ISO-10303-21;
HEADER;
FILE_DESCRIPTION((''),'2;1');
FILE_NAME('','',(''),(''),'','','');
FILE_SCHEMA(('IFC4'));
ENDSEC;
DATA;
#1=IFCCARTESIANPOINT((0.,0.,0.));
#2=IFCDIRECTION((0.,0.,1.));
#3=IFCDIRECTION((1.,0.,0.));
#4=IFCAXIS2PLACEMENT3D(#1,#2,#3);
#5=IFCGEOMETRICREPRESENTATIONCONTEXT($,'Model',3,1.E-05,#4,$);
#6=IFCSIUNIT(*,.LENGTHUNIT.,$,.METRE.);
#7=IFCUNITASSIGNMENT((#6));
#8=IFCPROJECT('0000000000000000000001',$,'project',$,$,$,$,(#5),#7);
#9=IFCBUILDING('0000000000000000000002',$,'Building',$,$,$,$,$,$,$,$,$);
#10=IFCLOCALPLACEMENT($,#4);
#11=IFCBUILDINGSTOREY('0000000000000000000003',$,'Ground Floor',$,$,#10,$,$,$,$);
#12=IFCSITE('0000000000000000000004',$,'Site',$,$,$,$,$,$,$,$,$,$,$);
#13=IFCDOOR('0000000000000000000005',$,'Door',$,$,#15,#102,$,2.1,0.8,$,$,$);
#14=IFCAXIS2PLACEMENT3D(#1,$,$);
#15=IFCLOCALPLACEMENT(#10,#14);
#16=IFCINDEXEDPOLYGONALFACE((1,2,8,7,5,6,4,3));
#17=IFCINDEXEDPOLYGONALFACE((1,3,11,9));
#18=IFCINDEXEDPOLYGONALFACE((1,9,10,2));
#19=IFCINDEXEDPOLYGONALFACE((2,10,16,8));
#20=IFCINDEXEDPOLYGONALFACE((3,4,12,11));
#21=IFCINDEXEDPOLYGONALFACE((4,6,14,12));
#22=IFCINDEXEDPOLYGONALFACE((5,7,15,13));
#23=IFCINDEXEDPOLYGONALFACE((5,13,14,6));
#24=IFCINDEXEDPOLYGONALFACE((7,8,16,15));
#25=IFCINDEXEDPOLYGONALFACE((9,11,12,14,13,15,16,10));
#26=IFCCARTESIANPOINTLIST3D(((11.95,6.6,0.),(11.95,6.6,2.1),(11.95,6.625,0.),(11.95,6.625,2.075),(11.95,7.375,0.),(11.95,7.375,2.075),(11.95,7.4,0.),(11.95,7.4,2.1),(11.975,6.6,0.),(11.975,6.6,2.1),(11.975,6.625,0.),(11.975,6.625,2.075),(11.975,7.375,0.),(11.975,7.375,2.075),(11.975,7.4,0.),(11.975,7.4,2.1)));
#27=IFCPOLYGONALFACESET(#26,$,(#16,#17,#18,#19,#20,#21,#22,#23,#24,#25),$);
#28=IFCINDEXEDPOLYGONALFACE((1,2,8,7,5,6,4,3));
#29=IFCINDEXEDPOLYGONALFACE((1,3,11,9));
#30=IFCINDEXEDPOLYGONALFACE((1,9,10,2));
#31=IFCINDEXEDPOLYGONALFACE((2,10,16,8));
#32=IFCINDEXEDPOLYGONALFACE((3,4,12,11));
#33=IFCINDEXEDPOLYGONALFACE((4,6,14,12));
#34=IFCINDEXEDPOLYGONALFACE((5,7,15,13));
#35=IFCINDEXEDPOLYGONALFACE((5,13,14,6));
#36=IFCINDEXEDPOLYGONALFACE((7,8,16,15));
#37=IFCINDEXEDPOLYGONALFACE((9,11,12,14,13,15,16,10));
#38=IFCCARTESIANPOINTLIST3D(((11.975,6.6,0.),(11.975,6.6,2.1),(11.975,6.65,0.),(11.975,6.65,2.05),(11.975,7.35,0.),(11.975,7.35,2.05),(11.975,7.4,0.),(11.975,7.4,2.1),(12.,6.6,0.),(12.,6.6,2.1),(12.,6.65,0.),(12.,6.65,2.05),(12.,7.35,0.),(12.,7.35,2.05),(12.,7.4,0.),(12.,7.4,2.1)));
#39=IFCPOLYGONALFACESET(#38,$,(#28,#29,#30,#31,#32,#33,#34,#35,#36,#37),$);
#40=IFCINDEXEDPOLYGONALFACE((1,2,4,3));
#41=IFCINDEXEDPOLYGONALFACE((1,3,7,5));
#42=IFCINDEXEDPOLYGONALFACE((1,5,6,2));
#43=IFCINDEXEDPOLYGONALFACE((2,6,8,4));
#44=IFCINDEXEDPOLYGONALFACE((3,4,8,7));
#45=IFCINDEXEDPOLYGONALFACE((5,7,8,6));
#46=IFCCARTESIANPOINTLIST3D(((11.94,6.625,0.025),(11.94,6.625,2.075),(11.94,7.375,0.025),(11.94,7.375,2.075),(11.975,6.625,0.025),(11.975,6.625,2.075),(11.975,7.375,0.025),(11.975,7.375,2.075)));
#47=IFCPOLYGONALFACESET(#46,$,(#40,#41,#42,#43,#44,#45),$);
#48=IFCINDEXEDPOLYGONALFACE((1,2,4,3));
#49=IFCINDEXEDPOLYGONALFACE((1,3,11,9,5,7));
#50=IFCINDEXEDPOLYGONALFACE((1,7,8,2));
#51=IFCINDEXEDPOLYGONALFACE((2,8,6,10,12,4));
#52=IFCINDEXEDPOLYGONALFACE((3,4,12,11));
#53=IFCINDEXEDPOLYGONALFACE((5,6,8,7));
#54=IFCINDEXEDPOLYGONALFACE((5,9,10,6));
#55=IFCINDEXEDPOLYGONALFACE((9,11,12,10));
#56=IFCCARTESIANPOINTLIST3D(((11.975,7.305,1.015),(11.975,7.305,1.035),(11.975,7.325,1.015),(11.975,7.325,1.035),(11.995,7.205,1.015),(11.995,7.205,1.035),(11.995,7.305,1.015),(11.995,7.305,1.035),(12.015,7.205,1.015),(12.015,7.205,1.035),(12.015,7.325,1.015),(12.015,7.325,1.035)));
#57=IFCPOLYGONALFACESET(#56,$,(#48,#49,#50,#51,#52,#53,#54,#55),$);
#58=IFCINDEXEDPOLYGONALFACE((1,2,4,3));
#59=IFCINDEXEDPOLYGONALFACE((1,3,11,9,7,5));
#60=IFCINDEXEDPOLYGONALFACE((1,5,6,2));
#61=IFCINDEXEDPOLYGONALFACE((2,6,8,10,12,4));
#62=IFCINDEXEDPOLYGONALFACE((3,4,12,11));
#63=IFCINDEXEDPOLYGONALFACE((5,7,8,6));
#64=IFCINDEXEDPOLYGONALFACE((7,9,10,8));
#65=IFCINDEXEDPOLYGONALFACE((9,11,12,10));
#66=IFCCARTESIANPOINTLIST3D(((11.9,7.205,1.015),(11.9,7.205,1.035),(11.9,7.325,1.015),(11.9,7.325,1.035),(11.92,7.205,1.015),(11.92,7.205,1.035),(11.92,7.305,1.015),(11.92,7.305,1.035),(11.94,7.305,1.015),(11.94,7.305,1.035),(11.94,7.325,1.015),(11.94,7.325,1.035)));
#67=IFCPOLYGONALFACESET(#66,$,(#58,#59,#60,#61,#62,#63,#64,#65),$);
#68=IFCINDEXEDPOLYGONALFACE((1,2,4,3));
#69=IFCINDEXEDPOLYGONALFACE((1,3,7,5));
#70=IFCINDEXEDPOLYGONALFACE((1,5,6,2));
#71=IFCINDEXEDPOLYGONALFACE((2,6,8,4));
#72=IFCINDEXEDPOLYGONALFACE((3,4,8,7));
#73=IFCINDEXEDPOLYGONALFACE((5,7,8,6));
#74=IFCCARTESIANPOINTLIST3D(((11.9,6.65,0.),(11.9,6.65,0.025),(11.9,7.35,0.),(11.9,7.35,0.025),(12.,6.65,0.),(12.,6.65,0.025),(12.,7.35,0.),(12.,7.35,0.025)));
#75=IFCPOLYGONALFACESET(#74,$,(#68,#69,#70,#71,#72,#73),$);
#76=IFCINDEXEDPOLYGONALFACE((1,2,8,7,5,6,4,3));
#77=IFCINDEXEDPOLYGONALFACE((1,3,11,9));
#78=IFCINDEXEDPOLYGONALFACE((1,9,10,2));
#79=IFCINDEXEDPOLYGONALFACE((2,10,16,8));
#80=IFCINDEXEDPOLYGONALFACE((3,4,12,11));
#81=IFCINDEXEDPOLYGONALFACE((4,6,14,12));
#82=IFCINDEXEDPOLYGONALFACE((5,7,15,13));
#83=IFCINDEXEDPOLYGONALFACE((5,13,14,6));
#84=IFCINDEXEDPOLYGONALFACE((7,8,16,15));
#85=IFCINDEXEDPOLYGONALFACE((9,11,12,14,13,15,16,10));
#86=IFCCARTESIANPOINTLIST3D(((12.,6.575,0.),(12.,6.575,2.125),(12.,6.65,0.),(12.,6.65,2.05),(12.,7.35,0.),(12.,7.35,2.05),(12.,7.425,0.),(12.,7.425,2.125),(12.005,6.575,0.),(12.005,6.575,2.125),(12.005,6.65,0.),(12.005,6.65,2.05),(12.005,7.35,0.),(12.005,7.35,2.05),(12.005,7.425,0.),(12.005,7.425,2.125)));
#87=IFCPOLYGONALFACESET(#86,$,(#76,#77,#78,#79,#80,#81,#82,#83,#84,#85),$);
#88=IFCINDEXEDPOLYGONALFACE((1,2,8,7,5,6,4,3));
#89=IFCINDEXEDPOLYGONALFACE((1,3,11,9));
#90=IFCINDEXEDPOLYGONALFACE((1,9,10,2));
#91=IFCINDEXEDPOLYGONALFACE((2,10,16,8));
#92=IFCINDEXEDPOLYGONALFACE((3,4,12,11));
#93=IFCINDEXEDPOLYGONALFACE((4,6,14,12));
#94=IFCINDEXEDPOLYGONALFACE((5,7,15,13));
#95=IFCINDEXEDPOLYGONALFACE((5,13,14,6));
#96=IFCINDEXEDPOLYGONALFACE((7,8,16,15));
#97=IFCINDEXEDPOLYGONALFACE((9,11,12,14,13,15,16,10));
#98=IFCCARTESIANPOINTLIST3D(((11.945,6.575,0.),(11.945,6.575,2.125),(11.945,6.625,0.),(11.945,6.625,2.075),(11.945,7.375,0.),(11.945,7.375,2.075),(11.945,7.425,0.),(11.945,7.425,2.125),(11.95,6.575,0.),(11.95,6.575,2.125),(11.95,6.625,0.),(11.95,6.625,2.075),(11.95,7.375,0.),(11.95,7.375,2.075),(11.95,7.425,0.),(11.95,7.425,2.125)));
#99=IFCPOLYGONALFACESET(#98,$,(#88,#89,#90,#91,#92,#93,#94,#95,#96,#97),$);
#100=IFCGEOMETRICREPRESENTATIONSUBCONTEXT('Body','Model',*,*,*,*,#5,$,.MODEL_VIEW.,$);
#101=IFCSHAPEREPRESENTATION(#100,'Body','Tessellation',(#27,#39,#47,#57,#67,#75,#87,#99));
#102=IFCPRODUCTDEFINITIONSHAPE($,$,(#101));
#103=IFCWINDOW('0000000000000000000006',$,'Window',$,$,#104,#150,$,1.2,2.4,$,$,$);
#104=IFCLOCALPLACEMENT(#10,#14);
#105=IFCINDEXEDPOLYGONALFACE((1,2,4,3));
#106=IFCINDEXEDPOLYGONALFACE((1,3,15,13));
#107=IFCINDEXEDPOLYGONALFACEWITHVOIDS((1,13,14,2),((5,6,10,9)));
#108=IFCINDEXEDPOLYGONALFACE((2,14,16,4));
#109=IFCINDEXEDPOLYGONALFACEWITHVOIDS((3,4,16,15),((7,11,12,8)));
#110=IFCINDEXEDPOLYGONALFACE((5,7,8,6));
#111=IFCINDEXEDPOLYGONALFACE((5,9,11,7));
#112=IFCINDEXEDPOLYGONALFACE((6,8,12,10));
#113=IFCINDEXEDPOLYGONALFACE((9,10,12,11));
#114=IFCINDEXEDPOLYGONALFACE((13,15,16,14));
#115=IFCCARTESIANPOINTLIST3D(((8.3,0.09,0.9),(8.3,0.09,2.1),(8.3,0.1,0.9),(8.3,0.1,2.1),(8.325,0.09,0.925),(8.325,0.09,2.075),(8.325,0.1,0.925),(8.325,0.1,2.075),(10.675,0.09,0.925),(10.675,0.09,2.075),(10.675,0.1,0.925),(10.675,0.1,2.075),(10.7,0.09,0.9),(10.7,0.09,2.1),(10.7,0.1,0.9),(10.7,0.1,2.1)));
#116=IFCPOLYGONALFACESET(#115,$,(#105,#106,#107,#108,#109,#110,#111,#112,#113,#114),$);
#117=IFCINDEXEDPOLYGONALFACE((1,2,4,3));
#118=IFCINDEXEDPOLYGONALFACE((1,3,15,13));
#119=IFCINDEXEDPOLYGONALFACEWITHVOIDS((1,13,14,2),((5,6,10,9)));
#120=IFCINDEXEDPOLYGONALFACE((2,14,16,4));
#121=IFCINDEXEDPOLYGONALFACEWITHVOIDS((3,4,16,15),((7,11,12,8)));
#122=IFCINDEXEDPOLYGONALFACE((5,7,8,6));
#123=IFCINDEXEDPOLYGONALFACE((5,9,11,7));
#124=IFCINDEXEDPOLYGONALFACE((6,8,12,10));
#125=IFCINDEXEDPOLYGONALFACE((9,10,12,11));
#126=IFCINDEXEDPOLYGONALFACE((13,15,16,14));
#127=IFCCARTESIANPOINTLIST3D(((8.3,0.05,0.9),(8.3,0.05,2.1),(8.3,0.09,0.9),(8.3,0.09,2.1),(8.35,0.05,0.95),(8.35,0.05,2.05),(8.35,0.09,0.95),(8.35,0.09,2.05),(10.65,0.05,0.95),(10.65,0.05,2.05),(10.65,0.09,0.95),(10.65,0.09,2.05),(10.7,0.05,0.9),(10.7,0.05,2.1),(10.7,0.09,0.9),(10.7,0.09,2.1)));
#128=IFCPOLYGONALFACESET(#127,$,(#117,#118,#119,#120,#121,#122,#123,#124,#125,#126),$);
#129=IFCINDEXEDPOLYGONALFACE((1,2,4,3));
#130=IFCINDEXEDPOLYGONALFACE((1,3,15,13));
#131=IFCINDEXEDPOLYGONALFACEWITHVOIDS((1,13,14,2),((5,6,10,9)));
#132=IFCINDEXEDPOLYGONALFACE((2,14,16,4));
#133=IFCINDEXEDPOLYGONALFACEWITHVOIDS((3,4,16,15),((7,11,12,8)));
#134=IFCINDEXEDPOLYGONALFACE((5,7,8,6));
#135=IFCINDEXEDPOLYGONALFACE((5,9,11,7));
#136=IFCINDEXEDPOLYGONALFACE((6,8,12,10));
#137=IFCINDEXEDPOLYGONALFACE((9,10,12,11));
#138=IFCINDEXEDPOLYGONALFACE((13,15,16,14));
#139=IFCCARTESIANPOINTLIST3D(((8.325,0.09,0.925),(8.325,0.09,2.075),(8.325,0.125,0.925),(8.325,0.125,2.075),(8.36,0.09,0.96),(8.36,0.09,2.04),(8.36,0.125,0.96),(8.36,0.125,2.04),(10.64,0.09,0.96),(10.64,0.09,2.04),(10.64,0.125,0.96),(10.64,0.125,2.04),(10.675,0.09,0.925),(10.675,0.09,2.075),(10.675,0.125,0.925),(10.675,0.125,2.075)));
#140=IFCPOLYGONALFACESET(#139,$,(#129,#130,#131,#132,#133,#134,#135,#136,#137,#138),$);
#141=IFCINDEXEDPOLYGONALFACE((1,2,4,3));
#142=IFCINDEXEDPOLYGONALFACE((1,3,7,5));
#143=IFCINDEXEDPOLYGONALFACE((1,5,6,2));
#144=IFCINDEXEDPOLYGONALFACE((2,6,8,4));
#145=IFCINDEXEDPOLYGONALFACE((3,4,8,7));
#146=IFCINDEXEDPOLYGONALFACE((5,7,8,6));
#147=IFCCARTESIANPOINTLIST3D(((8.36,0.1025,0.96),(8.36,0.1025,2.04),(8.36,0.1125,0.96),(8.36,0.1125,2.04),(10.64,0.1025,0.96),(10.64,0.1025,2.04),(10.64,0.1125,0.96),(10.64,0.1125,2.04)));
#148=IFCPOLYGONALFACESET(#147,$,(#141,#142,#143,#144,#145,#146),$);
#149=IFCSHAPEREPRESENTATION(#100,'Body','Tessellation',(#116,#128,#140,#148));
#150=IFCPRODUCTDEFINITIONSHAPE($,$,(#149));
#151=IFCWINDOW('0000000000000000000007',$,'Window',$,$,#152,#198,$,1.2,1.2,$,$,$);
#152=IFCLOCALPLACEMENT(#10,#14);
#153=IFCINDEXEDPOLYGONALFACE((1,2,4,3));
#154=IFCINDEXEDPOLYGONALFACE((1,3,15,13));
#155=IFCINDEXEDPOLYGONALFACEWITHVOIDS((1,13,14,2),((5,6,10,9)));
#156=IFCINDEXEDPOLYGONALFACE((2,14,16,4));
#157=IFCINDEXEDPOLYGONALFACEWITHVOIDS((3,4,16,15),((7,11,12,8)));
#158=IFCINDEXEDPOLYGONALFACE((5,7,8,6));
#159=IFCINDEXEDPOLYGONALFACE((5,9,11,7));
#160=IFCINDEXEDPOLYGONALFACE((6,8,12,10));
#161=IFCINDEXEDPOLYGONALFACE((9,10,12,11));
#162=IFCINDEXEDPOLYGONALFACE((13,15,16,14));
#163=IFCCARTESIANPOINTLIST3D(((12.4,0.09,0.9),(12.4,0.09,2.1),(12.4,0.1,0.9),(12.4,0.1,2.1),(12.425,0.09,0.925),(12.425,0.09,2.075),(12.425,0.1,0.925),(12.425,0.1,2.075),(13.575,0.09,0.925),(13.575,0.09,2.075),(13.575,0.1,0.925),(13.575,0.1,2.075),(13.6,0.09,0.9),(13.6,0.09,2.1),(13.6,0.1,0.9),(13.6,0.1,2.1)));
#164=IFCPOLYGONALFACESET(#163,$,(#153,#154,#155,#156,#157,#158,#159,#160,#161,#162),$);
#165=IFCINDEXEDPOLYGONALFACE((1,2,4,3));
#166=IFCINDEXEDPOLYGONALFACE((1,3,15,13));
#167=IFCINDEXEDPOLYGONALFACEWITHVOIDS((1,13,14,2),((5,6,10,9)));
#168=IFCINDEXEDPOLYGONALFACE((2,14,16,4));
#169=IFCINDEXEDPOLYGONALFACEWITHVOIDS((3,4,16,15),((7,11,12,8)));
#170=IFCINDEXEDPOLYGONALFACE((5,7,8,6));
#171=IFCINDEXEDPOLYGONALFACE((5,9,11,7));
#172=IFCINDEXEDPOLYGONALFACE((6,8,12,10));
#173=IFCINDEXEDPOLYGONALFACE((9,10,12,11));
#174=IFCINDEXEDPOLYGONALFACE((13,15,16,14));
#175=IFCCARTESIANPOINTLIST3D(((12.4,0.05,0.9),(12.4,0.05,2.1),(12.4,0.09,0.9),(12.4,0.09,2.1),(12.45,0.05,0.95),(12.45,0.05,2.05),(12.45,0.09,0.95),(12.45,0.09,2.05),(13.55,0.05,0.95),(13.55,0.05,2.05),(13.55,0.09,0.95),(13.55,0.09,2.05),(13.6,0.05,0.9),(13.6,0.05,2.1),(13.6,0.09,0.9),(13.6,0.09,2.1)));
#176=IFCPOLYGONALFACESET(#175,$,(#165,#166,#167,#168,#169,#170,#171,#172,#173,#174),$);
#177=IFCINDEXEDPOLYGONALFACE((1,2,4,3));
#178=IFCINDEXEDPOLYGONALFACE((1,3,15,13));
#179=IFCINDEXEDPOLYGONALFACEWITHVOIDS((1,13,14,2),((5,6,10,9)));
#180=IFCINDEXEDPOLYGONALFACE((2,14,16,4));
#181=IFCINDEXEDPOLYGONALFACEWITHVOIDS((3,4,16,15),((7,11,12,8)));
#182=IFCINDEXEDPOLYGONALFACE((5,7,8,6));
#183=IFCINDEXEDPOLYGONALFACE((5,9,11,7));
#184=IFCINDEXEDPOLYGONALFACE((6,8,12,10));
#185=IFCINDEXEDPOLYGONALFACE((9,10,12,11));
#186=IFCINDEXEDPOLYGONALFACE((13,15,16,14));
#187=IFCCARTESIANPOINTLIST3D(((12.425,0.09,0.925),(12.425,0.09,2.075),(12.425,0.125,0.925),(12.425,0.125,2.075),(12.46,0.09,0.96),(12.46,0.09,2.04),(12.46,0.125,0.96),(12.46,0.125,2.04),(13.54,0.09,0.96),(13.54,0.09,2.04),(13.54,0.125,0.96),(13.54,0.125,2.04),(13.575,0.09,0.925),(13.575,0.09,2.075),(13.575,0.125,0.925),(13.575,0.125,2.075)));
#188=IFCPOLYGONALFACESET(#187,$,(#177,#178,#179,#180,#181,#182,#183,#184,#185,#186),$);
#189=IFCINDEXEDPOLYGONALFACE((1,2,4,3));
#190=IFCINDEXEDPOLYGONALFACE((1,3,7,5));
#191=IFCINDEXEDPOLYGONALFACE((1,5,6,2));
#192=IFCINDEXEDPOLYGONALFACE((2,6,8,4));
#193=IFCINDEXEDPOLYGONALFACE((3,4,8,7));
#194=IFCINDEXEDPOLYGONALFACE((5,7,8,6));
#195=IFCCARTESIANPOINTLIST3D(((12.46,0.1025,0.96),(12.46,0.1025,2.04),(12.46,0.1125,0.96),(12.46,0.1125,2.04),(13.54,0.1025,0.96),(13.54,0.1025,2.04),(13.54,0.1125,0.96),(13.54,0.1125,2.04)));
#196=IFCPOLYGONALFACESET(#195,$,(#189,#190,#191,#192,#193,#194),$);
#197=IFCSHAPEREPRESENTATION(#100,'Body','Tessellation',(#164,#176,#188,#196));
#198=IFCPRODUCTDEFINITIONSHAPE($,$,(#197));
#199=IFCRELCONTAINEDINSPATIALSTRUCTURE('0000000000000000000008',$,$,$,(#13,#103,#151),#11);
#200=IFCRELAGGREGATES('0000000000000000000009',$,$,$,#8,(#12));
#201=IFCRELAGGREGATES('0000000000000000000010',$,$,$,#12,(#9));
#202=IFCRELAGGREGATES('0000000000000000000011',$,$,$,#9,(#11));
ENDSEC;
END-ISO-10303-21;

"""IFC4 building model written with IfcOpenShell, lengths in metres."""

from ifc_helpers import new_model, si_unit, frame, origin_with_axes, place, context, subcontext, project, spatial, line, indexed_curve, outline, extrude, element, save


model = new_model("IFC4")

# Units and contexts
model_context = context("Model", 3, precision=1e-05, world=origin_with_axes())
body_context = subcontext(model_context, "Body", "Model", "MODEL_VIEW")
ifc_project = project(units=[si_unit("LENGTHUNIT", "METRE")], contexts=[model_context])

# Site, building, storey
site = spatial("IfcSite", under=ifc_project, Name="Site")
building = spatial("IfcBuilding", under=site, Name="Building")
storey_placement = place(None, origin_with_axes())
storey = spatial("IfcBuildingStorey", under=building, at=storey_placement, Name="Ground Floor")

# Door
door_1_placement = place(storey_placement, frame((12.0, 6.6, 0.0), z_axis=(0.0, 0.0, 1.0), x_axis=(0.0, 1.0, 0.0)))
element("IfcDoor", 1, at=door_1_placement, inside=storey, Name="Door", OverallHeight=2.1, OverallWidth=0.8, context=body_context, shape_type="SweptSolid", body=[
    extrude(outline(indexed_curve([(0.0, 0.0), (0.0, 2.1), (0.8, 2.1), (0.8, 0.0), (0.775, 0.0), (0.775, 2.075), (0.025, 2.075), (0.025, 0.0)], segments=[line(1, 2, 3, 4, 5, 6, 7, 8, 1)])), frame((0.0, 0.025, 0.0), z_axis=(0.0, -1.0, 0.0), x_axis=(1.0, 0.0, 0.0)), (0.0, 0.0, -1.0), 0.025),
    extrude(outline(indexed_curve([(0.0, 0.0), (0.0, 2.1), (0.8, 2.1), (0.8, 0.0), (0.75, 0.0), (0.75, 2.05), (0.05, 2.05), (0.05, 0.0)], segments=[line(1, 2, 3, 4, 5, 6, 7, 8, 1)])), frame((0.0, 0.0, 0.0), z_axis=(0.0, -1.0, 0.0), x_axis=(1.0, 0.0, 0.0)), (0.0, 0.0, -1.0), 0.025),
    extrude(outline(indexed_curve([(0.0, 0.0), (0.75, 0.0), (0.75, 0.035), (0.0, 0.035)], segments=[line(1, 2, 3, 4, 1)])), frame((0.025, 0.025, 0.025), z_axis=(0.0, 0.0, 1.0), x_axis=(1.0, 0.0, 0.0)), (0.0, 0.0, 1.0), 2.05),
    extrude(outline(indexed_curve([(0.0, 0.0), (0.0, -0.04), (-0.12, -0.04), (-0.12, -0.02), (-0.02, -0.02), (-0.02, 0.0)], segments=[line(1, 2, 3, 4, 5, 6, 1)])), frame((0.725, 0.025, 1.015), z_axis=(0.0, 0.0, 1.0), x_axis=(1.0, 0.0, 0.0)), (0.0, 0.0, 1.0), 0.02),
    extrude(outline(indexed_curve([(0.0, 0.0), (0.0, 0.04), (-0.12, 0.04), (-0.12, 0.02), (-0.02, 0.02), (-0.02, 0.0)], segments=[line(1, 2, 3, 4, 5, 6, 1)])), frame((0.725, 0.06, 1.015), z_axis=(0.0, 0.0, 1.0), x_axis=(1.0, 0.0, 0.0)), (0.0, 0.0, 1.0), 0.02),
    extrude(outline(indexed_curve([(0.0, 0.0), (0.7, 0.0), (0.7, 0.1), (0.0, 0.1)], segments=[line(1, 2, 3, 4, 1)])), frame((0.05, 0.0, 0.0), z_axis=(0.0, 0.0, 1.0), x_axis=(1.0, 0.0, 0.0)), (0.0, 0.0, 1.0), 0.025),
    extrude(outline(indexed_curve([(0.0, 0.0), (0.0, 2.125), (0.85, 2.125), (0.85, 0.0), (0.775, 0.0), (0.775, 2.05), (0.075, 2.05), (0.075, 0.0)], segments=[line(1, 2, 3, 4, 5, 6, 7, 8, 1)])), frame((-0.025, -0.005, 0.0), z_axis=(0.0, -1.0, 0.0), x_axis=(1.0, 0.0, 0.0)), (0.0, 0.0, -1.0), 0.005),
    extrude(outline(indexed_curve([(0.0, 0.0), (0.0, 2.125), (0.85, 2.125), (0.85, 0.0), (0.8, 0.0), (0.8, 2.075), (0.05, 2.075), (0.05, 0.0)], segments=[line(1, 2, 3, 4, 5, 6, 7, 8, 1)])), frame((-0.025, 0.05, 0.0), z_axis=(0.0, -1.0, 0.0), x_axis=(1.0, 0.0, 0.0)), (0.0, 0.0, -1.0), 0.005),
])

# Windows
window_1_placement = place(storey_placement, frame((8.3, 0.0, 0.9), z_axis=(0.0, 0.0, 1.0), x_axis=(1.0, 0.0, 0.0)))
element("IfcWindow", 2, at=window_1_placement, inside=storey, Name="Window", OverallHeight=1.2, OverallWidth=2.4, context=body_context, shape_type="SweptSolid", body=[
    extrude(outline(indexed_curve([(0.0, 0.0), (2.4, 0.0), (2.4, 1.2), (0.0, 1.2)], segments=[line(1, 2, 3, 4, 1)]), holes=[indexed_curve([(0.025, 0.025), (2.375, 0.025), (2.375, 1.175), (0.025, 1.175)], segments=[line(1, 2, 3, 4, 1)])]), frame((0.0, 0.09, 0.0), z_axis=(0.0, -1.0, 0.0), x_axis=(1.0, 0.0, 0.0)), (0.0, 0.0, -1.0), 0.01),
    extrude(outline(indexed_curve([(0.0, 0.0), (2.4, 0.0), (2.4, 1.2), (0.0, 1.2)], segments=[line(1, 2, 3, 4, 1)]), holes=[indexed_curve([(0.05, 0.05), (2.35, 0.05), (2.35, 1.15), (0.05, 1.15)], segments=[line(1, 2, 3, 4, 1)])]), frame((0.0, 0.05, 0.0), z_axis=(0.0, -1.0, 0.0), x_axis=(1.0, 0.0, 0.0)), (0.0, 0.0, -1.0), 0.04),
    extrude(outline(indexed_curve([(0.0, 0.0), (2.35, 0.0), (2.35, 1.15), (0.0, 1.15)], segments=[line(1, 2, 3, 4, 1)]), holes=[indexed_curve([(0.035, 0.035), (2.315, 0.035), (2.315, 1.115), (0.035, 1.115)], segments=[line(1, 2, 3, 4, 1)])]), frame((0.025, 0.09, 0.025), z_axis=(0.0, -1.0, 0.0), x_axis=(1.0, 0.0, 0.0)), (0.0, 0.0, -1.0), 0.035),
    extrude(outline(indexed_curve([(0.035, 0.035), (2.315, 0.035), (2.315, 1.115), (0.035, 1.115)], segments=[line(1, 2, 3, 4, 1)])), frame((0.025, 0.1025, 0.025), z_axis=(0.0, -1.0, 0.0), x_axis=(1.0, 0.0, 0.0)), (0.0, 0.0, -1.0), 0.01),
])
for number, where, z_axis, x_axis, name in (
    (3, (12.4, 0.0, 0.9), (0.0, 0.0, 1.0), (1.0, 0.0, 0.0), "Window"),
):
    element("IfcWindow", number, at=place(storey_placement, frame(where, z_axis=z_axis, x_axis=x_axis)), inside=storey, Name=name, OverallHeight=1.2, OverallWidth=1.2, context=body_context, shape_type="SweptSolid", body=[
        extrude(outline(indexed_curve([(0.0, 0.0), (1.2, 0.0), (1.2, 1.2), (0.0, 1.2)], segments=[line(1, 2, 3, 4, 1)]), holes=[indexed_curve([(0.025, 0.025), (1.175, 0.025), (1.175, 1.175), (0.025, 1.175)], segments=[line(1, 2, 3, 4, 1)])]), frame((0.0, 0.09, 0.0), z_axis=(0.0, -1.0, 0.0), x_axis=(1.0, 0.0, 0.0)), (0.0, 0.0, -1.0), 0.01),
        extrude(outline(indexed_curve([(0.0, 0.0), (1.2, 0.0), (1.2, 1.2), (0.0, 1.2)], segments=[line(1, 2, 3, 4, 1)]), holes=[indexed_curve([(0.05, 0.05), (1.15, 0.05), (1.15, 1.15), (0.05, 1.15)], segments=[line(1, 2, 3, 4, 1)])]), frame((0.0, 0.05, 0.0), z_axis=(0.0, -1.0, 0.0), x_axis=(1.0, 0.0, 0.0)), (0.0, 0.0, -1.0), 0.04),
        extrude(outline(indexed_curve([(0.0, 0.0), (1.15, 0.0), (1.15, 1.15), (0.0, 1.15)], segments=[line(1, 2, 3, 4, 1)]), holes=[indexed_curve([(0.035, 0.035), (1.115, 0.035), (1.115, 1.115), (0.035, 1.115)], segments=[line(1, 2, 3, 4, 1)])]), frame((0.025, 0.09, 0.025), z_axis=(0.0, -1.0, 0.0), x_axis=(1.0, 0.0, 0.0)), (0.0, 0.0, -1.0), 0.035),
        extrude(outline(indexed_curve([(0.035, 0.035), (1.115, 0.035), (1.115, 1.115), (0.035, 1.115)], segments=[line(1, 2, 3, 4, 1)])), frame((0.025, 0.1025, 0.025), z_axis=(0.0, -1.0, 0.0), x_axis=(1.0, 0.0, 0.0)), (0.0, 0.0, -1.0), 0.01),
    ])

save(model, "model.ifc")
